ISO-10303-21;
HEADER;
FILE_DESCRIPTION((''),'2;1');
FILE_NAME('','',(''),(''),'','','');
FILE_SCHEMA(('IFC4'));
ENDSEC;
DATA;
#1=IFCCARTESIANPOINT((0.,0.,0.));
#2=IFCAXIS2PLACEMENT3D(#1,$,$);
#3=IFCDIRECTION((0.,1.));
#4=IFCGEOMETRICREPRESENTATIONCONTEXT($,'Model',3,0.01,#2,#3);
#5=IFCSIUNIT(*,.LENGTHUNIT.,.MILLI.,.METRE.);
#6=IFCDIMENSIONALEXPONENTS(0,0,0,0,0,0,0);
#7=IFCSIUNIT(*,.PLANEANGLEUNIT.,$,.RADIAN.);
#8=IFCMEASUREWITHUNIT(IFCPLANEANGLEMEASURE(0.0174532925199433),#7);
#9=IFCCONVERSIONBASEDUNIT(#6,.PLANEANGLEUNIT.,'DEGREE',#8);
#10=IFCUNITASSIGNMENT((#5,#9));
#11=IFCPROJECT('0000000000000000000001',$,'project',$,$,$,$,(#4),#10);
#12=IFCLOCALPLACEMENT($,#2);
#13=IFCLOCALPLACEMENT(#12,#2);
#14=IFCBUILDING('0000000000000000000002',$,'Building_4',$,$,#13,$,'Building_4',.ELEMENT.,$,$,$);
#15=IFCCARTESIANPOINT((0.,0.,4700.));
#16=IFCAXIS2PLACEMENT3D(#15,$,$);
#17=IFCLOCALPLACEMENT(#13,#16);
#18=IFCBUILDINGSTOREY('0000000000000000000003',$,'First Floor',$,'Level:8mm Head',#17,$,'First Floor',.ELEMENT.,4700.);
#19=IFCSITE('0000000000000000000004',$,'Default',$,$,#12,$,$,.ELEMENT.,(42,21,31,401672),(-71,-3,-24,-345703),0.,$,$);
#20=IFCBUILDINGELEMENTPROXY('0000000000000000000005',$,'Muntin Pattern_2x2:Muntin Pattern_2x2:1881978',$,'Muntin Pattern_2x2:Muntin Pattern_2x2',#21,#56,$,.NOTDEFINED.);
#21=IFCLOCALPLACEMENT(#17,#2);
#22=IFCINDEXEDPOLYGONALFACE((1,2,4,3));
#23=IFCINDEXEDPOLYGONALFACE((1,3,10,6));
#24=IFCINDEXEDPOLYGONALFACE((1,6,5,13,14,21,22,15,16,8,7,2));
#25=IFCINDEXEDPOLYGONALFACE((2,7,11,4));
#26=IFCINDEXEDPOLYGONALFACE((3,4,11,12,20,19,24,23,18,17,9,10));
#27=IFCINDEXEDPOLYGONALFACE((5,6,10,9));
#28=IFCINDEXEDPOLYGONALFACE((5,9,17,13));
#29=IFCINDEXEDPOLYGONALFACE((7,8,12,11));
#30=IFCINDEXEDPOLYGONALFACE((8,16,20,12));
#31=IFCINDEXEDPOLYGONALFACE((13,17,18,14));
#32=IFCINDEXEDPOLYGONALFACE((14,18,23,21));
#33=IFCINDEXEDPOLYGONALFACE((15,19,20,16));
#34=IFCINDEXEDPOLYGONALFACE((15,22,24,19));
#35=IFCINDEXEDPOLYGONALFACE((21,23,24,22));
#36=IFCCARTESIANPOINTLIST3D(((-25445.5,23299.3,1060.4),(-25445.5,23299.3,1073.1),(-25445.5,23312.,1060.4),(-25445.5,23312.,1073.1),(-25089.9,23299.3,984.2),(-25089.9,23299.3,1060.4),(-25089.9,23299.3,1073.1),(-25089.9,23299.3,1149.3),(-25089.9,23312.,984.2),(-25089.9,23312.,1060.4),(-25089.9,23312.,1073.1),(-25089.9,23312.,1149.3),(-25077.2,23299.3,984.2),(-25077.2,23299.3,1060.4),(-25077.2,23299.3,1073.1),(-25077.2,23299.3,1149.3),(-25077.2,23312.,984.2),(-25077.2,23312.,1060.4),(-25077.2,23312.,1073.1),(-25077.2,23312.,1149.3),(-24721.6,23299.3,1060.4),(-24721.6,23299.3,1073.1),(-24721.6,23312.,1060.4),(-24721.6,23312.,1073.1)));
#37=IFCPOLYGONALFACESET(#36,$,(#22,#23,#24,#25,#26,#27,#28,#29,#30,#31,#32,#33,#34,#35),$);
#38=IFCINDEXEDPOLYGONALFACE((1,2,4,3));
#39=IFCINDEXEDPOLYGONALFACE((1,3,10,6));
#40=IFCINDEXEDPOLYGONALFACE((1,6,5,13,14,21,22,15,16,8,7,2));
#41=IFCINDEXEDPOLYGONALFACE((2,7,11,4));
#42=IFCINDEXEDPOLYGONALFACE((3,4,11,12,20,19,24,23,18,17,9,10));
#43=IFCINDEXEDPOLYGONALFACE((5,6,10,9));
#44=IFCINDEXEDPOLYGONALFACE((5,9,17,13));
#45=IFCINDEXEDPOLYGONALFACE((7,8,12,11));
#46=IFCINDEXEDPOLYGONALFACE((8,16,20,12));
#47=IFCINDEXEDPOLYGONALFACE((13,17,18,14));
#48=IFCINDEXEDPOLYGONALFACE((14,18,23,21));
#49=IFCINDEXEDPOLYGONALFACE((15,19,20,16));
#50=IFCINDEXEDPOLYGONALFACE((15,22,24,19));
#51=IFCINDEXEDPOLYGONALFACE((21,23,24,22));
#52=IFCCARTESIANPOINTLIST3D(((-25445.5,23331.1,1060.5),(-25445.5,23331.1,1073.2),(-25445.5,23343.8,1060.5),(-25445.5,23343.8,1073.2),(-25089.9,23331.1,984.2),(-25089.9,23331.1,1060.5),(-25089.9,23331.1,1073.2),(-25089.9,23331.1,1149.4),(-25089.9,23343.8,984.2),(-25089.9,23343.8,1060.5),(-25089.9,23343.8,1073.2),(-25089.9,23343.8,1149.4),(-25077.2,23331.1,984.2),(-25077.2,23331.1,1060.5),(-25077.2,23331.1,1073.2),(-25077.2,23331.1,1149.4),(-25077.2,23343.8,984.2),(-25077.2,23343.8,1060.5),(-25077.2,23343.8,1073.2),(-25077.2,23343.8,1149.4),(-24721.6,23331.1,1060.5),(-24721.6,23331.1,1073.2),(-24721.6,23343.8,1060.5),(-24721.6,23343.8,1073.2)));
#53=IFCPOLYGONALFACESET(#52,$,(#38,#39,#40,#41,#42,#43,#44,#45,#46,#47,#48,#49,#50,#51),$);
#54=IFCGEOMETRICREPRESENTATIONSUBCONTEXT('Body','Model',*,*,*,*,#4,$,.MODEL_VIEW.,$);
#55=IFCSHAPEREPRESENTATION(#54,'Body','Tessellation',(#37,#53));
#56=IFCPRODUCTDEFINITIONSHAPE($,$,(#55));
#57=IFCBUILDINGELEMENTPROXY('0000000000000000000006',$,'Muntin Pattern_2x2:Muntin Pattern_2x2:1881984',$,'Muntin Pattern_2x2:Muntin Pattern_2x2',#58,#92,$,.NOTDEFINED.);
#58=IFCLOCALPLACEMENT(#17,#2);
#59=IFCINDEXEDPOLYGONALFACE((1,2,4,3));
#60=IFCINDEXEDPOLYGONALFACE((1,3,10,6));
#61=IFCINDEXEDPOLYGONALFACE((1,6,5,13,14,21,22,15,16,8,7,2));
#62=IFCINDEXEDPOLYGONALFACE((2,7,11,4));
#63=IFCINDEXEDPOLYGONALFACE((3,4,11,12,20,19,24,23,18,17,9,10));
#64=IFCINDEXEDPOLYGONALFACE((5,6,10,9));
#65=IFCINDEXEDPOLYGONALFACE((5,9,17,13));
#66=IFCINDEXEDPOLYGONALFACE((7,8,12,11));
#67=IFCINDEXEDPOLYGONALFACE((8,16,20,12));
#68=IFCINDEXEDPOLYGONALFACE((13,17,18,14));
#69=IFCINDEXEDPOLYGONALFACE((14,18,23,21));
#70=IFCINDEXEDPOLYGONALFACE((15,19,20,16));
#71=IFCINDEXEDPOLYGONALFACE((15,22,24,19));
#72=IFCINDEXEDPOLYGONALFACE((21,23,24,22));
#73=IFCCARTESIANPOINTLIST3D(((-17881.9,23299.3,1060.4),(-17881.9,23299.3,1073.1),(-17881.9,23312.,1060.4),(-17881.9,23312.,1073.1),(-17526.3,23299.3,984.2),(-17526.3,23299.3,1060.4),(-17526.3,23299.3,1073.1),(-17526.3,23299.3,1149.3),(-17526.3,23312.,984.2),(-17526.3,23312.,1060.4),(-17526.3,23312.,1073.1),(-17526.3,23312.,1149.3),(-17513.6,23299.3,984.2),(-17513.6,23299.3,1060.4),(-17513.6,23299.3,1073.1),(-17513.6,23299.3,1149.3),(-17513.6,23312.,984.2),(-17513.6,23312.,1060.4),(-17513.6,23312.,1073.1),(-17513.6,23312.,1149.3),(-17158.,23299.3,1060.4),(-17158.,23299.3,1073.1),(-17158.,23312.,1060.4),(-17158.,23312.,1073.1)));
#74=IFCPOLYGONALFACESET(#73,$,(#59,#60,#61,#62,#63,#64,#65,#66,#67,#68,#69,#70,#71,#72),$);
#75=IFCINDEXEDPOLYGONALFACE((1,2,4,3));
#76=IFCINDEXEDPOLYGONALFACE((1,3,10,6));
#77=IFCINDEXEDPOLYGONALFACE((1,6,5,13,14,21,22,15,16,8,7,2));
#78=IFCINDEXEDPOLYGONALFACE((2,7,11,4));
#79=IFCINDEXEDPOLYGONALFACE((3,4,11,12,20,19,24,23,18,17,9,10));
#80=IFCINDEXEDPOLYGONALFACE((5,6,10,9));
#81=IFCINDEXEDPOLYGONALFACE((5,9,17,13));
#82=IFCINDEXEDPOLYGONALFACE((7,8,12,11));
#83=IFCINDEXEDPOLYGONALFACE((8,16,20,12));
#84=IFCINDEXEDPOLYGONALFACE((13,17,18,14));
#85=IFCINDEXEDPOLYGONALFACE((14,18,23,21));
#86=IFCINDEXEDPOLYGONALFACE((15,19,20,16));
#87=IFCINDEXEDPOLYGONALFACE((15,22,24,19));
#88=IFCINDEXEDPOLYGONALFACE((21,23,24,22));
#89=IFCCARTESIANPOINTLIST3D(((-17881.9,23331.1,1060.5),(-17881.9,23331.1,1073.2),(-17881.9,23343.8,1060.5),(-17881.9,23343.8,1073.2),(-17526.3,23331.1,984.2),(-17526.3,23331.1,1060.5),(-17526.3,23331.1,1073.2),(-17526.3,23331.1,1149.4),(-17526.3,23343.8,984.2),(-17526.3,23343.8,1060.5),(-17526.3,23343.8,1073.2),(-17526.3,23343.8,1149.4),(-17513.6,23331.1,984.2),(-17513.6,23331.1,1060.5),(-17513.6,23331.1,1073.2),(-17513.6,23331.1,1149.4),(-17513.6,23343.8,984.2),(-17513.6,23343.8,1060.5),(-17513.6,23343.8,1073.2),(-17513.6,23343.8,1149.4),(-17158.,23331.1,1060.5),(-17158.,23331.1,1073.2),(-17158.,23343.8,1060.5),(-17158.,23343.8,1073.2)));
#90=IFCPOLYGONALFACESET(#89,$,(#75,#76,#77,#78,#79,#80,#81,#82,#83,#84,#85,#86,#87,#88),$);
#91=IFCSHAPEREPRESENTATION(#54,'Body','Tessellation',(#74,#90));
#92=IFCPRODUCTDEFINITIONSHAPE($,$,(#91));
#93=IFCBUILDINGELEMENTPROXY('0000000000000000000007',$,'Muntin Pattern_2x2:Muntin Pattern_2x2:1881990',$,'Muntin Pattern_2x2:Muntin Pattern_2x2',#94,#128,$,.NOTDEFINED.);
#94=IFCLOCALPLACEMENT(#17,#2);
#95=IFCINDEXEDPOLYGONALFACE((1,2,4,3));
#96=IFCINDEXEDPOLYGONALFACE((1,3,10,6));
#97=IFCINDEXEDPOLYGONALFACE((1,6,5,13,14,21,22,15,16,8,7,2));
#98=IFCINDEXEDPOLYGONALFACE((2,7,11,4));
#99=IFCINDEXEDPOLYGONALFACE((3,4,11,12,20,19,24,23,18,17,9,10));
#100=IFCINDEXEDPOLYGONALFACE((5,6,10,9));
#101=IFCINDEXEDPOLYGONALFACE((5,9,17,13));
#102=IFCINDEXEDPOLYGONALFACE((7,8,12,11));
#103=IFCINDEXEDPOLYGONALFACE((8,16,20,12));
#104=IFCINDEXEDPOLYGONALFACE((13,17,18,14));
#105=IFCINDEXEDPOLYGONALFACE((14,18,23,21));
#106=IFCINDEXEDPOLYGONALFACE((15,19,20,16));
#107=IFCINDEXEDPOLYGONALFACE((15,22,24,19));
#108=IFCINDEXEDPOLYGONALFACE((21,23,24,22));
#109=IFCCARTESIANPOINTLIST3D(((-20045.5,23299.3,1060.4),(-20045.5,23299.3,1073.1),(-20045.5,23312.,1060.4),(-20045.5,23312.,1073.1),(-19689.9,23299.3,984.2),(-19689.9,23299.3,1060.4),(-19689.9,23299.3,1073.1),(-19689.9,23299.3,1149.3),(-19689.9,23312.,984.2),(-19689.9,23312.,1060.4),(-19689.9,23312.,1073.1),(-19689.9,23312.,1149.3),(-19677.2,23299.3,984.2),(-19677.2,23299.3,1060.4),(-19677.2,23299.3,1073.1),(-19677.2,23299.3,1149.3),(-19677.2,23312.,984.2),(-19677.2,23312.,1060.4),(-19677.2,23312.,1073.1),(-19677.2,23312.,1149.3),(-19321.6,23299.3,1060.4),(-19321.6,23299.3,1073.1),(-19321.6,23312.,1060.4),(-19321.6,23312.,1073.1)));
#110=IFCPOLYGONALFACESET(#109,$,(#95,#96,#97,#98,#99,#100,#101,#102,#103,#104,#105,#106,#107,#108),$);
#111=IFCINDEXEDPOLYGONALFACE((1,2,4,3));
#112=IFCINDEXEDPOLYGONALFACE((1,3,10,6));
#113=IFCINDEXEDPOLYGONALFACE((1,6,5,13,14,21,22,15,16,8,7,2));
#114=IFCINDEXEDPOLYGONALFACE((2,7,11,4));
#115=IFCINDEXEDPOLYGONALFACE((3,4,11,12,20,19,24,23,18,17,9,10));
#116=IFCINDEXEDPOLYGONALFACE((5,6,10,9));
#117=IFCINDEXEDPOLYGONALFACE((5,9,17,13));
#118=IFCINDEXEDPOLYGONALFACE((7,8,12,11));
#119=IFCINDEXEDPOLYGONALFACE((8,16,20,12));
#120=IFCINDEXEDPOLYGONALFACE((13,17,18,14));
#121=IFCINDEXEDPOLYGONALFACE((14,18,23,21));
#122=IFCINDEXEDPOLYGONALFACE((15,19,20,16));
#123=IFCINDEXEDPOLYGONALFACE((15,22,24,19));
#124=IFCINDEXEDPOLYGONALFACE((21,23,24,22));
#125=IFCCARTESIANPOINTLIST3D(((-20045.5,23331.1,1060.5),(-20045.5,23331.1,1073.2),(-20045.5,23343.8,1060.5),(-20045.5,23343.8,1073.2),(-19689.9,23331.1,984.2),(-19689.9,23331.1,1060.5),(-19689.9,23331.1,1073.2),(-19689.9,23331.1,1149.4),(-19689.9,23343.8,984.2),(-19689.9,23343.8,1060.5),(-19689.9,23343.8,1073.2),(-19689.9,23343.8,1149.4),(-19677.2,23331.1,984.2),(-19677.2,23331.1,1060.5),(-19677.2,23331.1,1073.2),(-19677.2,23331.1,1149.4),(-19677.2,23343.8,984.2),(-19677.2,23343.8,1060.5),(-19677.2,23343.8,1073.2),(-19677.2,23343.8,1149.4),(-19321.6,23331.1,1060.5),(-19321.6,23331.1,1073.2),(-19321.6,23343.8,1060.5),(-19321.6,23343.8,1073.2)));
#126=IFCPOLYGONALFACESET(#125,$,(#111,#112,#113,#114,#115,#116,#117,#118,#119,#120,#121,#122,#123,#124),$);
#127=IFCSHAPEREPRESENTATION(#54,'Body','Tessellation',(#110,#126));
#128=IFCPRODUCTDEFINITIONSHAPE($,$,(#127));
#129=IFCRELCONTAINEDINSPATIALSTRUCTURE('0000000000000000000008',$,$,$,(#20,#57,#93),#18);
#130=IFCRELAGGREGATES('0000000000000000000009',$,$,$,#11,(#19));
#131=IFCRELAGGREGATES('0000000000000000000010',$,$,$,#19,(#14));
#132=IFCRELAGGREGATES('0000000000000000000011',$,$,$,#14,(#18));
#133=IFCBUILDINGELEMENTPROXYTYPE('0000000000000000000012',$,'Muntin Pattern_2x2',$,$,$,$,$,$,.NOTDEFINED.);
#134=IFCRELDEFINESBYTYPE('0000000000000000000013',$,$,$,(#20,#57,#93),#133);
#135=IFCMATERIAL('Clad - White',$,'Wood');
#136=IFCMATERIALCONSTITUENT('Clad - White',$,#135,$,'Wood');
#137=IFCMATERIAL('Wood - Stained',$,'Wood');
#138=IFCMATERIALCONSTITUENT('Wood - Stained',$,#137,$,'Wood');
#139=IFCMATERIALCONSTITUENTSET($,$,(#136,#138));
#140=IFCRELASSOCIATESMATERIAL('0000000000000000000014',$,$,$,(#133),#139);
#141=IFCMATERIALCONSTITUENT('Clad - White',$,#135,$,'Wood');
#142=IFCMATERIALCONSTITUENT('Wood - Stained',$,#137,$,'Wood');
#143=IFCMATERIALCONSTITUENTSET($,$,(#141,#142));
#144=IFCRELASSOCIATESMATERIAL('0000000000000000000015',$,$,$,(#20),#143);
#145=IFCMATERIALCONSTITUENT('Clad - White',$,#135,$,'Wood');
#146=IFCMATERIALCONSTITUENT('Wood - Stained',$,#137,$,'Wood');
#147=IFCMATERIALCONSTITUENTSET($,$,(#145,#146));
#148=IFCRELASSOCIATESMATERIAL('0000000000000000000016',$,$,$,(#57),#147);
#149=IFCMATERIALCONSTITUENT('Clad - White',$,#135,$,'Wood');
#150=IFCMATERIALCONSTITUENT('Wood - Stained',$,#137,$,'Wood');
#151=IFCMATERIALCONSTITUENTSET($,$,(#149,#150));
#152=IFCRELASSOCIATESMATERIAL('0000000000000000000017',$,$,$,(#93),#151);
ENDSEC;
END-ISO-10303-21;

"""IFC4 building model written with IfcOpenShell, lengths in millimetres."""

from ifc_helpers import new_model, entity, si_unit, converted_unit, direction, frame, origin, place, context, subcontext, project, spatial, indexed_curve, outline, extrude, source, transform, mapped, material, constituent, constituent_set, type_object, type_shapes, element, save


model = new_model("IFC4")

# Units and contexts
model_context = context("Model", 3, precision=0.01, world=origin(), true_north=direction((0.0, 1.0)))
body_context = subcontext(model_context, "Body", "Model", "MODEL_VIEW")
ifc_project = project(units=[si_unit("LENGTHUNIT", "METRE", prefix="MILLI"), converted_unit("PLANEANGLEUNIT", "DEGREE", entity("IfcPlaneAngleMeasure", 0.0174532925199433), si_unit("PLANEANGLEUNIT", "RADIAN"), dimensions=[0, 0, 0, 0, 0, 0, 0])], contexts=[model_context])

# Site, building, storey
site_placement = place(None, origin())
site = spatial("IfcSite", under=ifc_project, at=site_placement, Name="Default", CompositionType="ELEMENT", RefLatitude=(42, 21, 31, 401672), RefLongitude=(-71, -3, -24, -345703), RefElevation=0.0)
building_placement = place(site_placement, origin())
building = spatial("IfcBuilding", under=site, at=building_placement, Name="Building_4", LongName="Building_4", CompositionType="ELEMENT")
storey_placement = place(building_placement, frame((0.0, 0.0, 4700.0)))
storey = spatial("IfcBuildingStorey", under=building, at=storey_placement, Name="First Floor", ObjectType="Level:8mm Head", LongName="First Floor", CompositionType="ELEMENT", Elevation=4700.0)

# Shared definitions
ifc_material_1 = material(Name="Clad - White", Category="Wood")
ifc_material_2 = material(Name="Wood - Stained", Category="Wood")

# Building element proxies
ifc_constituent_1 = constituent(ifc_material_1, Name="Clad - White", Category="Wood")
ifc_constituent_2 = constituent(ifc_material_2, Name="Wood - Stained", Category="Wood")
ifc_constituent_set_1 = constituent_set(constituents=[ifc_constituent_1, ifc_constituent_2])
building_element_proxy_type_1 = type_object("IfcBuildingElementProxyType", Name="Muntin Pattern_2x2", PredefinedType="NOTDEFINED", material=ifc_constituent_set_1)
shared_shape_1 = source(origin(), body_context, "Body", "SweptSolid", [
    extrude(outline(indexed_curve([(6.4, -6.4), (82.5, -6.4), (82.5, 6.3), (6.4, 6.3), (6.4, 362.0), (-6.3, 362.0), (-6.3, 6.3), (-82.6, 6.3), (-82.6, -6.4), (-6.3, -6.4), (-6.3, -361.9), (6.4, -361.9), (6.4, -6.4)], self_intersect=False)), frame((0.0, -22.2, 82.5), z_axis=(0.0, 1.0, 0.0), x_axis=(0.0, 0.0, 1.0)), (0.0, 0.0, 1.0), 12.7),
    extrude(outline(indexed_curve([(6.4, -6.4), (82.6, -6.4), (82.6, 6.3), (6.4, 6.3), (6.4, 362.0), (-6.3, 362.0), (-6.3, 6.3), (-82.6, 6.3), (-82.6, -6.4), (-6.3, -6.4), (-6.3, -361.9), (6.4, -361.9), (6.4, -6.4)], self_intersect=False)), frame((0.0, 9.5, 82.6), z_axis=(0.0, 1.0, 0.0), x_axis=(0.0, 0.0, 1.0)), (0.0, 0.0, 1.0), 12.7),
])
type_shapes(building_element_proxy_type_1, [shared_shape_1])
ifc_constituent_3 = constituent(ifc_material_1, Name="Clad - White", Category="Wood")
ifc_constituent_4 = constituent(ifc_material_2, Name="Wood - Stained", Category="Wood")
ifc_constituent_set_2 = constituent_set(constituents=[ifc_constituent_3, ifc_constituent_4])
proxy_1_placement = place(storey_placement, frame((-25083.6, 23321.5, 984.2)))
element("IfcBuildingElementProxy", 1, at=proxy_1_placement, inside=storey, type_object=building_element_proxy_type_1, material=ifc_constituent_set_2, Name="Muntin Pattern_2x2:Muntin Pattern_2x2:1881978", ObjectType="Muntin Pattern_2x2:Muntin Pattern_2x2", PredefinedType="NOTDEFINED", context=body_context, shape_type="MappedRepresentation", body=[
    mapped(shared_shape_1, transform((0.0, 0.0, 0.0), scale=1.0)),
])
ifc_constituent_5 = constituent(ifc_material_1, Name="Clad - White", Category="Wood")
ifc_constituent_6 = constituent(ifc_material_2, Name="Wood - Stained", Category="Wood")
ifc_constituent_set_3 = constituent_set(constituents=[ifc_constituent_5, ifc_constituent_6])
proxy_2_placement = place(storey_placement, frame((-17520.0, 23321.5, 984.2)))
element("IfcBuildingElementProxy", 2, at=proxy_2_placement, inside=storey, type_object=building_element_proxy_type_1, material=ifc_constituent_set_3, Name="Muntin Pattern_2x2:Muntin Pattern_2x2:1881984", ObjectType="Muntin Pattern_2x2:Muntin Pattern_2x2", PredefinedType="NOTDEFINED", context=body_context, shape_type="MappedRepresentation", body=[
    mapped(shared_shape_1, transform((0.0, 0.0, 0.0), scale=1.0)),
])
ifc_constituent_7 = constituent(ifc_material_1, Name="Clad - White", Category="Wood")
ifc_constituent_8 = constituent(ifc_material_2, Name="Wood - Stained", Category="Wood")
ifc_constituent_set_4 = constituent_set(constituents=[ifc_constituent_7, ifc_constituent_8])
proxy_3_placement = place(storey_placement, frame((-19683.6, 23321.5, 984.2)))
element("IfcBuildingElementProxy", 3, at=proxy_3_placement, inside=storey, type_object=building_element_proxy_type_1, material=ifc_constituent_set_4, Name="Muntin Pattern_2x2:Muntin Pattern_2x2:1881990", ObjectType="Muntin Pattern_2x2:Muntin Pattern_2x2", PredefinedType="NOTDEFINED", context=body_context, shape_type="MappedRepresentation", body=[
    mapped(shared_shape_1, transform((0.0, 0.0, 0.0), scale=1.0)),
])

save(model, "model.ifc")
